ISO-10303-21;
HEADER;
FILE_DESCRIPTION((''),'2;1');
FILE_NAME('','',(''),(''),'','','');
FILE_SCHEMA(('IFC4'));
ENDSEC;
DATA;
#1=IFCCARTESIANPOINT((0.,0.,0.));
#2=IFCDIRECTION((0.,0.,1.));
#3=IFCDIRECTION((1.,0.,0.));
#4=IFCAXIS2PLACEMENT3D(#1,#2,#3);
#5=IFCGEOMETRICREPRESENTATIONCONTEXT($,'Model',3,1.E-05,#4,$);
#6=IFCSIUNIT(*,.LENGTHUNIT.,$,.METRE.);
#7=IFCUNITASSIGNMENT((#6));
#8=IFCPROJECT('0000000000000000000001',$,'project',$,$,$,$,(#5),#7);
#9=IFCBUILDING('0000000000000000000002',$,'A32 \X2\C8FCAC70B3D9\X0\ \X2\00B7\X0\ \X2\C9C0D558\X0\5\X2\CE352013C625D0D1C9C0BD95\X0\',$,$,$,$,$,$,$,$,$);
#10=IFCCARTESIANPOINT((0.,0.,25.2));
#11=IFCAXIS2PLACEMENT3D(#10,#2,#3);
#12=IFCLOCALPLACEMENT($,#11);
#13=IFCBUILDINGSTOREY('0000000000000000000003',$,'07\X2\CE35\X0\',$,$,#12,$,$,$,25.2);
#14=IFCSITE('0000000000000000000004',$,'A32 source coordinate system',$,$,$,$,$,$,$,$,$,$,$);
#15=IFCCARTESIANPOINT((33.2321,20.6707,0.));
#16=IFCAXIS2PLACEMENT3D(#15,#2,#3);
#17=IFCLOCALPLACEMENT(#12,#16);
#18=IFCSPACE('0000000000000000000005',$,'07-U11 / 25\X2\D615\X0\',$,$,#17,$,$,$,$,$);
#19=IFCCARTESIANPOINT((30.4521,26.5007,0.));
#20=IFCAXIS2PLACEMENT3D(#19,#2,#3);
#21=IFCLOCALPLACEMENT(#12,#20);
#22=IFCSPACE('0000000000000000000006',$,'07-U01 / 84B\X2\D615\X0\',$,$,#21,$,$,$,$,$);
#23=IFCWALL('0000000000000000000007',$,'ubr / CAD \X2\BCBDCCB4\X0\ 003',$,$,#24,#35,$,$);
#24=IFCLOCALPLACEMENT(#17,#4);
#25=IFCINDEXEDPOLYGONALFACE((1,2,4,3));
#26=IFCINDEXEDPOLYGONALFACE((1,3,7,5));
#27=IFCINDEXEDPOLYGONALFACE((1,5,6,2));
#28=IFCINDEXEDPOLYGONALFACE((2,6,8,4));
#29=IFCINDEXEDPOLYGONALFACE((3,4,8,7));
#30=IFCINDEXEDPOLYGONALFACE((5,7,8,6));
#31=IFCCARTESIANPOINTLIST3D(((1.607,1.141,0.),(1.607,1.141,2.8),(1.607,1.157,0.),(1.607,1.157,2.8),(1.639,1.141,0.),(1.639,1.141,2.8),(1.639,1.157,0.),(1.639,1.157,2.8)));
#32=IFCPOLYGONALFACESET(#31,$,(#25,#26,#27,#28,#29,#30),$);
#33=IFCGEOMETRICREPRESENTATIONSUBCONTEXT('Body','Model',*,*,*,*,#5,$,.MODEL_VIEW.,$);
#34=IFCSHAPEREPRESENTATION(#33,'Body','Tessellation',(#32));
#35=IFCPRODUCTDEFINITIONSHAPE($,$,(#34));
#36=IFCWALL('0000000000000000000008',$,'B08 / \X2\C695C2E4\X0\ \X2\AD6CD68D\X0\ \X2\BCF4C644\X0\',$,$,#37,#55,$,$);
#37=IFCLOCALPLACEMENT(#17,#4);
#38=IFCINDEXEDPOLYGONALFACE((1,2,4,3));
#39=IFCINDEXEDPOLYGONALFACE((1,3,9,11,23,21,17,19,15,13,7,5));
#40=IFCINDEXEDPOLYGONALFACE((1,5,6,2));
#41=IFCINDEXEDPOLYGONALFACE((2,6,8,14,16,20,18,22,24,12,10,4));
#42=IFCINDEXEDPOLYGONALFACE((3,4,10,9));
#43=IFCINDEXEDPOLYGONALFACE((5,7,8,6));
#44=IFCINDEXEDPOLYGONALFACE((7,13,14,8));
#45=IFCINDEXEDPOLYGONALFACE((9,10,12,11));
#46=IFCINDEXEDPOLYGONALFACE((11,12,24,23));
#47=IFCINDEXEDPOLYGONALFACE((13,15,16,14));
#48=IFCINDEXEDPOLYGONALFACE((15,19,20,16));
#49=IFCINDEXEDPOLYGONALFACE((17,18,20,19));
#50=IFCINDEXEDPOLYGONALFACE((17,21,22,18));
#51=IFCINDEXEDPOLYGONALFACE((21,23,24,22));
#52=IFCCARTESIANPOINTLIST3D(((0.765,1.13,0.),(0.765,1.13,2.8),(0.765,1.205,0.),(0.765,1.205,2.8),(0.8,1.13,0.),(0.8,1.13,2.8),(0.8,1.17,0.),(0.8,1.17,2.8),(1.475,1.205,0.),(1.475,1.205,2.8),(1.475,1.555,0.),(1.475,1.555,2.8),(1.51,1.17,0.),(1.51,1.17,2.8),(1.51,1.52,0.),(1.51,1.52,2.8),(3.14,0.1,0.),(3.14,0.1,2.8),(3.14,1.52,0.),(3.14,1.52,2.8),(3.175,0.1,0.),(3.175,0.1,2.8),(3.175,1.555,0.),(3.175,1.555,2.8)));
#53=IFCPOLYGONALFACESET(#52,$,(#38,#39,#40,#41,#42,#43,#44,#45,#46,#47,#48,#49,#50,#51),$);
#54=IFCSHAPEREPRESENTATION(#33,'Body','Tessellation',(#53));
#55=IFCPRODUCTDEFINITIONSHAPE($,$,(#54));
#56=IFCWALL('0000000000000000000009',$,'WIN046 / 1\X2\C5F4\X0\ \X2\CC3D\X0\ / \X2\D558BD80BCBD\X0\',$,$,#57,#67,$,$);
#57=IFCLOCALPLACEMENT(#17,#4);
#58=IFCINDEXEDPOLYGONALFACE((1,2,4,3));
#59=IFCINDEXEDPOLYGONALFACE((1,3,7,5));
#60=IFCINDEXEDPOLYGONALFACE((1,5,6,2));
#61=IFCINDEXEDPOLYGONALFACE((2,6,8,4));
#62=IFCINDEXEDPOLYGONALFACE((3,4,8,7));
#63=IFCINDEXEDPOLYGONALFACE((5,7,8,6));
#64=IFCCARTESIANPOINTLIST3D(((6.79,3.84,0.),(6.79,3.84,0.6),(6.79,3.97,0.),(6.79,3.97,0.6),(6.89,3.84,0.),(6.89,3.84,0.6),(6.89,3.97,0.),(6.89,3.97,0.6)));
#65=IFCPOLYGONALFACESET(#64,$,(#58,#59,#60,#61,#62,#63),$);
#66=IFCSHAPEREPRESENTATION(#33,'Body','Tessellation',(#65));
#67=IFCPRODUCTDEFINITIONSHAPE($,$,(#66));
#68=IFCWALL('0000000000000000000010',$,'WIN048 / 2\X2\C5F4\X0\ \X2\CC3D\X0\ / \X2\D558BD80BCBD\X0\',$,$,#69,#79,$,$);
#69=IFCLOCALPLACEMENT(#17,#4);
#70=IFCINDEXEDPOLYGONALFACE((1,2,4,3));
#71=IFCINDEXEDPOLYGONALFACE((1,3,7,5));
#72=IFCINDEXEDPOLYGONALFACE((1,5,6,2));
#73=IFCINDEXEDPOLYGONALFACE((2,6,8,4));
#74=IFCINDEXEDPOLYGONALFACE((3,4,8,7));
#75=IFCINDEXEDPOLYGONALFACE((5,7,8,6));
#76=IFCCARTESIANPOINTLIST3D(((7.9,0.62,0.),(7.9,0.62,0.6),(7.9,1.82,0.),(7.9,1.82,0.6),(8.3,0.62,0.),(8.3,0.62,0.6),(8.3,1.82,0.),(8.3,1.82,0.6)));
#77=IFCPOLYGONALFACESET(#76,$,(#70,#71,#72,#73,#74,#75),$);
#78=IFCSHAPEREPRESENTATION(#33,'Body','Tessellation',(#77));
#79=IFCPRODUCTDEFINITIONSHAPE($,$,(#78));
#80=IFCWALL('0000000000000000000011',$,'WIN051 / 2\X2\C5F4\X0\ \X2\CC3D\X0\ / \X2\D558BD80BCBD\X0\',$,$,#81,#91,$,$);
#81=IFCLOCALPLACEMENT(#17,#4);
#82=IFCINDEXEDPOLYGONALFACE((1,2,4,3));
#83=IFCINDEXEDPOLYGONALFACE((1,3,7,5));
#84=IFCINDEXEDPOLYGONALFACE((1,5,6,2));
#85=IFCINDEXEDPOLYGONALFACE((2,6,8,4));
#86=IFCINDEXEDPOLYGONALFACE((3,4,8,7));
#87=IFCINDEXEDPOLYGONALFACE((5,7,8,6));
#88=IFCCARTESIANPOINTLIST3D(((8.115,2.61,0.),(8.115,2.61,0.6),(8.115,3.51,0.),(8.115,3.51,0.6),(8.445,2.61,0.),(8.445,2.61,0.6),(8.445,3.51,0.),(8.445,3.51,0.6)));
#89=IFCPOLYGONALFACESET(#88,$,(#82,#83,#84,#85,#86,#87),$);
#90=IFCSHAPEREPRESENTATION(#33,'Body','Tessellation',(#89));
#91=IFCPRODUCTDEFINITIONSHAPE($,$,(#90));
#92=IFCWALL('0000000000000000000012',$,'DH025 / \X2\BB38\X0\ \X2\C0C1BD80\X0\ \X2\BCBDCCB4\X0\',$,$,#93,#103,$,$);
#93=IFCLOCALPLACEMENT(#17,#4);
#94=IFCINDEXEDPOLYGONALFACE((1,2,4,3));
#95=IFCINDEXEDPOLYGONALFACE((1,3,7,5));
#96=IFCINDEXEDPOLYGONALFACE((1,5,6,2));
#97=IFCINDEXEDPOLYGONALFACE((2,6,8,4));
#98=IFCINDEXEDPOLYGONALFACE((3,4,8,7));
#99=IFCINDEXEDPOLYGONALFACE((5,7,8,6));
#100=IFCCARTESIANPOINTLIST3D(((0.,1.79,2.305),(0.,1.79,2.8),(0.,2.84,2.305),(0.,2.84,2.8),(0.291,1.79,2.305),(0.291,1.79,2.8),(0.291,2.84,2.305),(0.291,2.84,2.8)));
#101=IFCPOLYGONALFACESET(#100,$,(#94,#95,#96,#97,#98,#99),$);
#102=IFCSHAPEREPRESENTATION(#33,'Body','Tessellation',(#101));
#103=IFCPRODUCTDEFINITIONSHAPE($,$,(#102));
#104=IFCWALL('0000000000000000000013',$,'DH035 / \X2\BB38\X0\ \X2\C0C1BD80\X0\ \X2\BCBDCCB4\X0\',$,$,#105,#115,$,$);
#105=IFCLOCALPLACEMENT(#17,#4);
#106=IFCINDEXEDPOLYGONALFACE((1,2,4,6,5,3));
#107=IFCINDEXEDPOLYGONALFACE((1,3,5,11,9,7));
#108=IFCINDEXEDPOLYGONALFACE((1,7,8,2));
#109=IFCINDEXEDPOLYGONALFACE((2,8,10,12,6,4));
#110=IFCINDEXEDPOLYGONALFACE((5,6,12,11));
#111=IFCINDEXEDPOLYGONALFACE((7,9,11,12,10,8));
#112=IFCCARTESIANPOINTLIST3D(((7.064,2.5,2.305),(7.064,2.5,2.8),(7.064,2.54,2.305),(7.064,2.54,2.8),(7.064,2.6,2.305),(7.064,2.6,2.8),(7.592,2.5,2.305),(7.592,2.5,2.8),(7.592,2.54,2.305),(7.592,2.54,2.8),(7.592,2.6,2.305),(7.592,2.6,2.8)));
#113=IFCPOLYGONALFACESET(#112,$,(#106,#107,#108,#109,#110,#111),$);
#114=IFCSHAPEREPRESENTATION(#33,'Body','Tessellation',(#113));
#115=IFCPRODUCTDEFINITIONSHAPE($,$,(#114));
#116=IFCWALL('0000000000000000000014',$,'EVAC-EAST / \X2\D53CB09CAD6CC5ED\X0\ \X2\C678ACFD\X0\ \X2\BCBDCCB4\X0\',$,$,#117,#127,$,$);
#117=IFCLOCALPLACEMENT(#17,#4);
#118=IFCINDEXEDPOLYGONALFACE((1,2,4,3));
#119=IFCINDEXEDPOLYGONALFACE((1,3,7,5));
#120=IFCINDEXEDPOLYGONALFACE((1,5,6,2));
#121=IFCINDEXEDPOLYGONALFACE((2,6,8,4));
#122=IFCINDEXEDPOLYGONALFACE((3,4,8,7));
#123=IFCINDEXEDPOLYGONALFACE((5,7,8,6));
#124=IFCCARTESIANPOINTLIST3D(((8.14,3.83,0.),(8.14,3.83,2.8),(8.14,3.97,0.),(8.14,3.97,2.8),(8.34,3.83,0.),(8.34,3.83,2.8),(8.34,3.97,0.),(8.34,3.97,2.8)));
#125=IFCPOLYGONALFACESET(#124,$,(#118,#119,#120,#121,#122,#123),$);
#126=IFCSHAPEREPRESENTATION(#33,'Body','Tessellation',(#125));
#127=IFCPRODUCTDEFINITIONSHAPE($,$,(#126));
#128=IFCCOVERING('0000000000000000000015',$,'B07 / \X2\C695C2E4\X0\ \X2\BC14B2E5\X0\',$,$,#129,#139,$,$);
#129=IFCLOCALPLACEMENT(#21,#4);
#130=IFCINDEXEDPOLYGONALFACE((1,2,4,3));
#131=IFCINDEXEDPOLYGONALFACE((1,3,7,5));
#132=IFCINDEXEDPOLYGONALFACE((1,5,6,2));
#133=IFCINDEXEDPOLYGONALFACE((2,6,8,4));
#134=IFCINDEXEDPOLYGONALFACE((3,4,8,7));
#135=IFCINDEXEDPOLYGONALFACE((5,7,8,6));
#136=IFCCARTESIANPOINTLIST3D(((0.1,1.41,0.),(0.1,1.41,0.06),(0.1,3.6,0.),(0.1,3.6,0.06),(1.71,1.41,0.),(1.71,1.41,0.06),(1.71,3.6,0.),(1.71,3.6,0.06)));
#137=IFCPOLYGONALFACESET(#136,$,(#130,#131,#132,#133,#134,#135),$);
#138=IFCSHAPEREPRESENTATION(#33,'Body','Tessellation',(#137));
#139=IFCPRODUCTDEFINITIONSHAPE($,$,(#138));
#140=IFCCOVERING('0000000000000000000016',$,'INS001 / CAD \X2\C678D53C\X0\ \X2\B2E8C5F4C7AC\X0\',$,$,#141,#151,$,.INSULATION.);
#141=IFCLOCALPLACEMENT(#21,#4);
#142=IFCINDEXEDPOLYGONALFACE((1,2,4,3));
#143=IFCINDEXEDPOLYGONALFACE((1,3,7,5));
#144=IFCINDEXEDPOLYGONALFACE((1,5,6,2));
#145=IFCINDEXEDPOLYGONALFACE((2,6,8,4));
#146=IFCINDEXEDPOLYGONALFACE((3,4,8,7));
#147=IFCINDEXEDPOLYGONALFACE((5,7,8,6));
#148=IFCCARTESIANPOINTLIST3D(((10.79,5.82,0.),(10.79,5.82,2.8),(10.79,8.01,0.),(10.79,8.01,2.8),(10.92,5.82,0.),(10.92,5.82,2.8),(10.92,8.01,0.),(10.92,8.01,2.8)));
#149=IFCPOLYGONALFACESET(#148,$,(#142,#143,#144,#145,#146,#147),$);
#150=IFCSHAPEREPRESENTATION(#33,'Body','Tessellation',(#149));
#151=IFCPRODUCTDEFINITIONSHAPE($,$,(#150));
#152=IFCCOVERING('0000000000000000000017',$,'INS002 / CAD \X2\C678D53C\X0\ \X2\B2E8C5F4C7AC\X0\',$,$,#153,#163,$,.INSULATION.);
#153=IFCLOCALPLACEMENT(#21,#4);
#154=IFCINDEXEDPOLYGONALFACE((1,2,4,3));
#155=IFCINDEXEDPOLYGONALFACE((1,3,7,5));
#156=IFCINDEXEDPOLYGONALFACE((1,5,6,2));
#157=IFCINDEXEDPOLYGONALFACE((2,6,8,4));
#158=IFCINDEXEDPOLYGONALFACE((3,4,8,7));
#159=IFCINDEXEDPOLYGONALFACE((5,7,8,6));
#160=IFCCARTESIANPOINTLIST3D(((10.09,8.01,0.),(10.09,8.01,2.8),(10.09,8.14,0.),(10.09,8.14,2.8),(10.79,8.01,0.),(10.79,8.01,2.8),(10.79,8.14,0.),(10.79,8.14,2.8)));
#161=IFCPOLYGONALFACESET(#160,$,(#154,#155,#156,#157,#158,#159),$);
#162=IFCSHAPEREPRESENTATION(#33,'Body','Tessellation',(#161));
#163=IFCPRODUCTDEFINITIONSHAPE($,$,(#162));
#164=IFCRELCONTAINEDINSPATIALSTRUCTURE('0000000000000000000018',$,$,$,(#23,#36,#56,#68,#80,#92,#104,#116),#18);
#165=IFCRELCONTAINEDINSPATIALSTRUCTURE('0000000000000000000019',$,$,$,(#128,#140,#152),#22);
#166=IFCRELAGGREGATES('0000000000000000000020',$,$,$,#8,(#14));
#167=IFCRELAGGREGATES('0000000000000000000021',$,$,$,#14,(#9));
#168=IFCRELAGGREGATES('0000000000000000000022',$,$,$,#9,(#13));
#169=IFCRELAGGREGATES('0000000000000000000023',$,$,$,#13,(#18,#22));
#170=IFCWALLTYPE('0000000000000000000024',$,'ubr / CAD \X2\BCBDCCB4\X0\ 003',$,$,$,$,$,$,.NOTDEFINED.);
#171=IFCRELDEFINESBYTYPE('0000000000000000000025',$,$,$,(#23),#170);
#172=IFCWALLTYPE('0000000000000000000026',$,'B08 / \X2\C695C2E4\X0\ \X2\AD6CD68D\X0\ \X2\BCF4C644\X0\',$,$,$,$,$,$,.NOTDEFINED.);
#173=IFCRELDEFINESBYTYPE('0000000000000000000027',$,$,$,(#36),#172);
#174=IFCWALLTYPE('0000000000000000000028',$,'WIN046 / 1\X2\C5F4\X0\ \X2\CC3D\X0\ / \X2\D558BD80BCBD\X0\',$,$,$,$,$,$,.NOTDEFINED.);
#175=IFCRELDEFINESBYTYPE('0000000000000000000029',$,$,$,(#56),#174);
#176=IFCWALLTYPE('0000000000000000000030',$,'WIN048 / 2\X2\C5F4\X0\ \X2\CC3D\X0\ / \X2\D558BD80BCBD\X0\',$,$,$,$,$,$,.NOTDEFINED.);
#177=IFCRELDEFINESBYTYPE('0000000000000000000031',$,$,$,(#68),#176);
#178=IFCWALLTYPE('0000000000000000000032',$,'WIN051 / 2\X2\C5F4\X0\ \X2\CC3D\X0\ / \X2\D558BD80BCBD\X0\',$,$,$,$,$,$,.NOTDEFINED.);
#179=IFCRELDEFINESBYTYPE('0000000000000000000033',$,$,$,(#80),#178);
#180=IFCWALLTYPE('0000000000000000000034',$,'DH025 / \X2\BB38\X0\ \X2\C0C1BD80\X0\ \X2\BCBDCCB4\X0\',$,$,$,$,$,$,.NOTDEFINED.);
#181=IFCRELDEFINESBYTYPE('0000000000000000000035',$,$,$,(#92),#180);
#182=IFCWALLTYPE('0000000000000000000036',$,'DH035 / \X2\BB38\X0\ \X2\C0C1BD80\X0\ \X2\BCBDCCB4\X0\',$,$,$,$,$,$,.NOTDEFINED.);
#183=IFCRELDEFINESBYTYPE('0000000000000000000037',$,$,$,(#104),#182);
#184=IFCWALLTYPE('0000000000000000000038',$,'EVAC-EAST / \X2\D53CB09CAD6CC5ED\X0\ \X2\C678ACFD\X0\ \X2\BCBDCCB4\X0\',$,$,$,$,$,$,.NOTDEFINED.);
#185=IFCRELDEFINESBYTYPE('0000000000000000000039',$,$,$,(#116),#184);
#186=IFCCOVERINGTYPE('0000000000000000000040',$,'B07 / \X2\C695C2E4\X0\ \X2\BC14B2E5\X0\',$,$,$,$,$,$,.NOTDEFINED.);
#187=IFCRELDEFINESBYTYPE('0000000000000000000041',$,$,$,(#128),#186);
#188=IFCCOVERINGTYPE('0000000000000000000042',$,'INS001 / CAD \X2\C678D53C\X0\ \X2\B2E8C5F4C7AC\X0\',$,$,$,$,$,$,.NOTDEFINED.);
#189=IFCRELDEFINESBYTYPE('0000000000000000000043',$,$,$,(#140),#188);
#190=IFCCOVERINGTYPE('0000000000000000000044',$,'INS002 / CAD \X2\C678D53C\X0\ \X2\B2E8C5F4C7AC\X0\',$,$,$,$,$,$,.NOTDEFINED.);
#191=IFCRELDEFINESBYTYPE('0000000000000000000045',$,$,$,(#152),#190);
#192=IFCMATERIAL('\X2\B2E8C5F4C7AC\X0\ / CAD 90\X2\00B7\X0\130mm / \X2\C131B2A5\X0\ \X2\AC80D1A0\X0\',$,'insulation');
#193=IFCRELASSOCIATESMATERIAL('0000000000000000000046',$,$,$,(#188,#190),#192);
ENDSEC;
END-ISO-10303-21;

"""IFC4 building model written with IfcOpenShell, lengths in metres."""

from ifc_helpers import new_model, si_unit, frame, origin, origin_with_axes, place, context, subcontext, project, spatial, polyline, outline, extrude, source, transform, mapped, material, type_object, type_shapes, element, save


model = new_model("IFC4")

# Units and contexts
model_context = context("Model", 3, precision=1e-05, world=origin_with_axes())
body_context = subcontext(model_context, "Body", "Model", "MODEL_VIEW")
ifc_project = project(units=[si_unit("LENGTHUNIT", "METRE")], contexts=[model_context])

# Site, building, storey, space
site = spatial("IfcSite", under=ifc_project, Name="A32 source coordinate system")
building = spatial("IfcBuilding", under=site, Name="A32 주거동 · 지하5층–옥탑지붕")
storey_placement = place(None, frame((0.0, 0.0, 25.2), z_axis=(0.0, 0.0, 1.0), x_axis=(1.0, 0.0, 0.0)))
storey = spatial("IfcBuildingStorey", under=building, at=storey_placement, Name="07층", Elevation=25.2)
space_1_placement = place(storey_placement, frame((33.2321, 20.6707, 0.0), z_axis=(0.0, 0.0, 1.0), x_axis=(1.0, 0.0, 0.0)))
space_1 = spatial("IfcSpace", under=storey, at=space_1_placement, Name="07-U11 / 25형")

# Walls
wall_type_1 = type_object("IfcWallType", Name="ubr / CAD 벽체 003", PredefinedType="NOTDEFINED")
shared_shape_1 = source(origin(), body_context, "Body", "SweptSolid", [
    extrude(outline(polyline([(1.639, 1.157), (1.639, 1.141), (1.607, 1.141), (1.607, 1.157), (1.639, 1.157)])), origin(), (0.0, 0.0, 1.0), 2.8),
])
type_shapes(wall_type_1, [shared_shape_1])
wall_1_placement = place(space_1_placement, origin_with_axes())
element("IfcWall", 1, at=wall_1_placement, inside=space_1, type_object=wall_type_1, Name="ubr / CAD 벽체 003", context=body_context, shape_type="MappedRepresentation", body=[
    mapped(shared_shape_1, transform((0.0, 0.0, 0.0), scale=1.0)),
])
wall_type_2 = type_object("IfcWallType", Name="B08 / 욕실 구획 보완", PredefinedType="NOTDEFINED")
shared_shape_2 = source(origin(), body_context, "Body", "SweptSolid", [
    extrude(outline(polyline([(0.765, 1.205), (1.475, 1.205), (1.475, 1.555), (3.175, 1.555), (3.175, 0.1), (3.14, 0.1), (3.14, 1.52), (1.51, 1.52), (1.51, 1.17), (0.8, 1.17), (0.8, 1.13), (0.765, 1.13), (0.765, 1.205)])), origin(), (0.0, 0.0, 1.0), 2.8),
])
type_shapes(wall_type_2, [shared_shape_2])
wall_2_placement = place(space_1_placement, origin_with_axes())
element("IfcWall", 2, at=wall_2_placement, inside=space_1, type_object=wall_type_2, Name="B08 / 욕실 구획 보완", context=body_context, shape_type="MappedRepresentation", body=[
    mapped(shared_shape_2, transform((0.0, 0.0, 0.0), scale=1.0)),
])
wall_type_3 = type_object("IfcWallType", Name="WIN046 / 1열 창 / 하부벽", PredefinedType="NOTDEFINED")
shared_shape_3 = source(origin(), body_context, "Body", "SweptSolid", [
    extrude(outline(polyline([(6.89, 3.84), (6.79, 3.84), (6.79, 3.97), (6.89, 3.97), (6.89, 3.84)])), origin(), (0.0, 0.0, 1.0), 0.6),
])
type_shapes(wall_type_3, [shared_shape_3])
wall_3_placement = place(space_1_placement, origin_with_axes())
element("IfcWall", 3, at=wall_3_placement, inside=space_1, type_object=wall_type_3, Name="WIN046 / 1열 창 / 하부벽", context=body_context, shape_type="MappedRepresentation", body=[
    mapped(shared_shape_3, transform((0.0, 0.0, 0.0), scale=1.0)),
])
wall_type_4 = type_object("IfcWallType", Name="WIN048 / 2열 창 / 하부벽", PredefinedType="NOTDEFINED")
shared_shape_4 = source(origin(), body_context, "Body", "SweptSolid", [
    extrude(outline(polyline([(8.3, 0.62), (7.9, 0.62), (7.9, 1.82), (8.3, 1.82), (8.3, 0.62)])), origin(), (0.0, 0.0, 1.0), 0.6),
])
type_shapes(wall_type_4, [shared_shape_4])
wall_4_placement = place(space_1_placement, origin_with_axes())
element("IfcWall", 4, at=wall_4_placement, inside=space_1, type_object=wall_type_4, Name="WIN048 / 2열 창 / 하부벽", context=body_context, shape_type="MappedRepresentation", body=[
    mapped(shared_shape_4, transform((0.0, 0.0, 0.0), scale=1.0)),
])
wall_type_5 = type_object("IfcWallType", Name="WIN051 / 2열 창 / 하부벽", PredefinedType="NOTDEFINED")
shared_shape_5 = source(origin(), body_context, "Body", "SweptSolid", [
    extrude(outline(polyline([(8.445, 2.61), (8.115, 2.61), (8.115, 3.51), (8.445, 3.51), (8.445, 2.61)])), origin(), (0.0, 0.0, 1.0), 0.6),
])
type_shapes(wall_type_5, [shared_shape_5])
wall_5_placement = place(space_1_placement, origin_with_axes())
element("IfcWall", 5, at=wall_5_placement, inside=space_1, type_object=wall_type_5, Name="WIN051 / 2열 창 / 하부벽", context=body_context, shape_type="MappedRepresentation", body=[
    mapped(shared_shape_5, transform((0.0, 0.0, 0.0), scale=1.0)),
])
wall_type_6 = type_object("IfcWallType", Name="DH025 / 문 상부 벽체", PredefinedType="NOTDEFINED")
shared_shape_6 = source(origin(), body_context, "Body", "SweptSolid", [
    extrude(outline(polyline([(0.0, 1.79), (0.0, 2.84), (0.291, 2.84), (0.291, 1.79), (0.0, 1.79)])), frame((0.0, 0.0, 2.305)), (0.0, 0.0, 1.0), 0.495),
])
type_shapes(wall_type_6, [shared_shape_6])
wall_6_placement = place(space_1_placement, origin_with_axes())
element("IfcWall", 6, at=wall_6_placement, inside=space_1, type_object=wall_type_6, Name="DH025 / 문 상부 벽체", context=body_context, shape_type="MappedRepresentation", body=[
    mapped(shared_shape_6, transform((0.0, 0.0, 0.0), scale=1.0)),
])
wall_type_7 = type_object("IfcWallType", Name="DH035 / 문 상부 벽체", PredefinedType="NOTDEFINED")
shared_shape_7 = source(origin(), body_context, "Body", "SweptSolid", [
    extrude(outline(polyline([(7.592, 2.6), (7.592, 2.54), (7.592, 2.5), (7.064, 2.5), (7.064, 2.54), (7.064, 2.6), (7.592, 2.6)])), frame((0.0, 0.0, 2.305)), (0.0, 0.0, 1.0), 0.495),
])
type_shapes(wall_type_7, [shared_shape_7])
wall_7_placement = place(space_1_placement, origin_with_axes())
element("IfcWall", 7, at=wall_7_placement, inside=space_1, type_object=wall_type_7, Name="DH035 / 문 상부 벽체", context=body_context, shape_type="MappedRepresentation", body=[
    mapped(shared_shape_7, transform((0.0, 0.0, 0.0), scale=1.0)),
])
wall_type_8 = type_object("IfcWallType", Name="EVAC-EAST / 피난구역 외곽 벽체", PredefinedType="NOTDEFINED")
shared_shape_8 = source(origin(), body_context, "Body", "SweptSolid", [
    extrude(outline(polyline([(8.34, 3.83), (8.14, 3.83), (8.14, 3.97), (8.34, 3.97), (8.34, 3.83)])), origin(), (0.0, 0.0, 1.0), 2.8),
])
type_shapes(wall_type_8, [shared_shape_8])
wall_8_placement = place(space_1_placement, origin_with_axes())
element("IfcWall", 8, at=wall_8_placement, inside=space_1, type_object=wall_type_8, Name="EVAC-EAST / 피난구역 외곽 벽체", context=body_context, shape_type="MappedRepresentation", body=[
    mapped(shared_shape_8, transform((0.0, 0.0, 0.0), scale=1.0)),
])

# Shared definitions
space_2_placement = place(storey_placement, frame((30.4521, 26.5007, 0.0), z_axis=(0.0, 0.0, 1.0), x_axis=(1.0, 0.0, 0.0)))
space_2 = spatial("IfcSpace", under=storey, at=space_2_placement, Name="07-U01 / 84B형")

# Coverings
covering_type_1 = type_object("IfcCoveringType", Name="B07 / 욕실 바닥", PredefinedType="NOTDEFINED")
shared_shape_9 = source(origin(), body_context, "Body", "SweptSolid", [
    extrude(outline(polyline([(1.71, 1.41), (0.1, 1.41), (0.1, 3.6), (1.71, 3.6), (1.71, 1.41)])), origin(), (0.0, 0.0, 1.0), 0.06),
])
type_shapes(covering_type_1, [shared_shape_9])
covering_1_placement = place(space_2_placement, origin_with_axes())
element("IfcCovering", 9, at=covering_1_placement, inside=space_2, type_object=covering_type_1, Name="B07 / 욕실 바닥", context=body_context, shape_type="MappedRepresentation", body=[
    mapped(shared_shape_9, transform((0.0, 0.0, 0.0), scale=1.0)),
])
ifc_material = material(Name="단열재 / CAD 90·130mm / 성능 검토", Category="insulation")
covering_type_2 = type_object("IfcCoveringType", Name="INS001 / CAD 외피 단열재", PredefinedType="NOTDEFINED", material=ifc_material)
shared_shape_10 = source(origin(), body_context, "Body", "SweptSolid", [
    extrude(outline(polyline([(10.79, 5.82), (10.79, 8.01), (10.92, 8.01), (10.92, 5.82), (10.79, 5.82)])), origin(), (0.0, 0.0, 1.0), 2.8),
])
type_shapes(covering_type_2, [shared_shape_10])
covering_2_placement = place(space_2_placement, origin_with_axes())
element("IfcCovering", 10, at=covering_2_placement, inside=space_2, type_object=covering_type_2, Name="INS001 / CAD 외피 단열재", PredefinedType="INSULATION", context=body_context, shape_type="MappedRepresentation", body=[
    mapped(shared_shape_10, transform((0.0, 0.0, 0.0), scale=1.0)),
])
covering_type_3 = type_object("IfcCoveringType", Name="INS002 / CAD 외피 단열재", PredefinedType="NOTDEFINED", material=ifc_material)
shared_shape_11 = source(origin(), body_context, "Body", "SweptSolid", [
    extrude(outline(polyline([(10.79, 8.01), (10.09, 8.01), (10.09, 8.14), (10.79, 8.14), (10.79, 8.01)])), origin(), (0.0, 0.0, 1.0), 2.8),
])
type_shapes(covering_type_3, [shared_shape_11])
covering_3_placement = place(space_2_placement, origin_with_axes())
element("IfcCovering", 11, at=covering_3_placement, inside=space_2, type_object=covering_type_3, Name="INS002 / CAD 외피 단열재", PredefinedType="INSULATION", context=body_context, shape_type="MappedRepresentation", body=[
    mapped(shared_shape_11, transform((0.0, 0.0, 0.0), scale=1.0)),
])

save(model, "model.ifc")
